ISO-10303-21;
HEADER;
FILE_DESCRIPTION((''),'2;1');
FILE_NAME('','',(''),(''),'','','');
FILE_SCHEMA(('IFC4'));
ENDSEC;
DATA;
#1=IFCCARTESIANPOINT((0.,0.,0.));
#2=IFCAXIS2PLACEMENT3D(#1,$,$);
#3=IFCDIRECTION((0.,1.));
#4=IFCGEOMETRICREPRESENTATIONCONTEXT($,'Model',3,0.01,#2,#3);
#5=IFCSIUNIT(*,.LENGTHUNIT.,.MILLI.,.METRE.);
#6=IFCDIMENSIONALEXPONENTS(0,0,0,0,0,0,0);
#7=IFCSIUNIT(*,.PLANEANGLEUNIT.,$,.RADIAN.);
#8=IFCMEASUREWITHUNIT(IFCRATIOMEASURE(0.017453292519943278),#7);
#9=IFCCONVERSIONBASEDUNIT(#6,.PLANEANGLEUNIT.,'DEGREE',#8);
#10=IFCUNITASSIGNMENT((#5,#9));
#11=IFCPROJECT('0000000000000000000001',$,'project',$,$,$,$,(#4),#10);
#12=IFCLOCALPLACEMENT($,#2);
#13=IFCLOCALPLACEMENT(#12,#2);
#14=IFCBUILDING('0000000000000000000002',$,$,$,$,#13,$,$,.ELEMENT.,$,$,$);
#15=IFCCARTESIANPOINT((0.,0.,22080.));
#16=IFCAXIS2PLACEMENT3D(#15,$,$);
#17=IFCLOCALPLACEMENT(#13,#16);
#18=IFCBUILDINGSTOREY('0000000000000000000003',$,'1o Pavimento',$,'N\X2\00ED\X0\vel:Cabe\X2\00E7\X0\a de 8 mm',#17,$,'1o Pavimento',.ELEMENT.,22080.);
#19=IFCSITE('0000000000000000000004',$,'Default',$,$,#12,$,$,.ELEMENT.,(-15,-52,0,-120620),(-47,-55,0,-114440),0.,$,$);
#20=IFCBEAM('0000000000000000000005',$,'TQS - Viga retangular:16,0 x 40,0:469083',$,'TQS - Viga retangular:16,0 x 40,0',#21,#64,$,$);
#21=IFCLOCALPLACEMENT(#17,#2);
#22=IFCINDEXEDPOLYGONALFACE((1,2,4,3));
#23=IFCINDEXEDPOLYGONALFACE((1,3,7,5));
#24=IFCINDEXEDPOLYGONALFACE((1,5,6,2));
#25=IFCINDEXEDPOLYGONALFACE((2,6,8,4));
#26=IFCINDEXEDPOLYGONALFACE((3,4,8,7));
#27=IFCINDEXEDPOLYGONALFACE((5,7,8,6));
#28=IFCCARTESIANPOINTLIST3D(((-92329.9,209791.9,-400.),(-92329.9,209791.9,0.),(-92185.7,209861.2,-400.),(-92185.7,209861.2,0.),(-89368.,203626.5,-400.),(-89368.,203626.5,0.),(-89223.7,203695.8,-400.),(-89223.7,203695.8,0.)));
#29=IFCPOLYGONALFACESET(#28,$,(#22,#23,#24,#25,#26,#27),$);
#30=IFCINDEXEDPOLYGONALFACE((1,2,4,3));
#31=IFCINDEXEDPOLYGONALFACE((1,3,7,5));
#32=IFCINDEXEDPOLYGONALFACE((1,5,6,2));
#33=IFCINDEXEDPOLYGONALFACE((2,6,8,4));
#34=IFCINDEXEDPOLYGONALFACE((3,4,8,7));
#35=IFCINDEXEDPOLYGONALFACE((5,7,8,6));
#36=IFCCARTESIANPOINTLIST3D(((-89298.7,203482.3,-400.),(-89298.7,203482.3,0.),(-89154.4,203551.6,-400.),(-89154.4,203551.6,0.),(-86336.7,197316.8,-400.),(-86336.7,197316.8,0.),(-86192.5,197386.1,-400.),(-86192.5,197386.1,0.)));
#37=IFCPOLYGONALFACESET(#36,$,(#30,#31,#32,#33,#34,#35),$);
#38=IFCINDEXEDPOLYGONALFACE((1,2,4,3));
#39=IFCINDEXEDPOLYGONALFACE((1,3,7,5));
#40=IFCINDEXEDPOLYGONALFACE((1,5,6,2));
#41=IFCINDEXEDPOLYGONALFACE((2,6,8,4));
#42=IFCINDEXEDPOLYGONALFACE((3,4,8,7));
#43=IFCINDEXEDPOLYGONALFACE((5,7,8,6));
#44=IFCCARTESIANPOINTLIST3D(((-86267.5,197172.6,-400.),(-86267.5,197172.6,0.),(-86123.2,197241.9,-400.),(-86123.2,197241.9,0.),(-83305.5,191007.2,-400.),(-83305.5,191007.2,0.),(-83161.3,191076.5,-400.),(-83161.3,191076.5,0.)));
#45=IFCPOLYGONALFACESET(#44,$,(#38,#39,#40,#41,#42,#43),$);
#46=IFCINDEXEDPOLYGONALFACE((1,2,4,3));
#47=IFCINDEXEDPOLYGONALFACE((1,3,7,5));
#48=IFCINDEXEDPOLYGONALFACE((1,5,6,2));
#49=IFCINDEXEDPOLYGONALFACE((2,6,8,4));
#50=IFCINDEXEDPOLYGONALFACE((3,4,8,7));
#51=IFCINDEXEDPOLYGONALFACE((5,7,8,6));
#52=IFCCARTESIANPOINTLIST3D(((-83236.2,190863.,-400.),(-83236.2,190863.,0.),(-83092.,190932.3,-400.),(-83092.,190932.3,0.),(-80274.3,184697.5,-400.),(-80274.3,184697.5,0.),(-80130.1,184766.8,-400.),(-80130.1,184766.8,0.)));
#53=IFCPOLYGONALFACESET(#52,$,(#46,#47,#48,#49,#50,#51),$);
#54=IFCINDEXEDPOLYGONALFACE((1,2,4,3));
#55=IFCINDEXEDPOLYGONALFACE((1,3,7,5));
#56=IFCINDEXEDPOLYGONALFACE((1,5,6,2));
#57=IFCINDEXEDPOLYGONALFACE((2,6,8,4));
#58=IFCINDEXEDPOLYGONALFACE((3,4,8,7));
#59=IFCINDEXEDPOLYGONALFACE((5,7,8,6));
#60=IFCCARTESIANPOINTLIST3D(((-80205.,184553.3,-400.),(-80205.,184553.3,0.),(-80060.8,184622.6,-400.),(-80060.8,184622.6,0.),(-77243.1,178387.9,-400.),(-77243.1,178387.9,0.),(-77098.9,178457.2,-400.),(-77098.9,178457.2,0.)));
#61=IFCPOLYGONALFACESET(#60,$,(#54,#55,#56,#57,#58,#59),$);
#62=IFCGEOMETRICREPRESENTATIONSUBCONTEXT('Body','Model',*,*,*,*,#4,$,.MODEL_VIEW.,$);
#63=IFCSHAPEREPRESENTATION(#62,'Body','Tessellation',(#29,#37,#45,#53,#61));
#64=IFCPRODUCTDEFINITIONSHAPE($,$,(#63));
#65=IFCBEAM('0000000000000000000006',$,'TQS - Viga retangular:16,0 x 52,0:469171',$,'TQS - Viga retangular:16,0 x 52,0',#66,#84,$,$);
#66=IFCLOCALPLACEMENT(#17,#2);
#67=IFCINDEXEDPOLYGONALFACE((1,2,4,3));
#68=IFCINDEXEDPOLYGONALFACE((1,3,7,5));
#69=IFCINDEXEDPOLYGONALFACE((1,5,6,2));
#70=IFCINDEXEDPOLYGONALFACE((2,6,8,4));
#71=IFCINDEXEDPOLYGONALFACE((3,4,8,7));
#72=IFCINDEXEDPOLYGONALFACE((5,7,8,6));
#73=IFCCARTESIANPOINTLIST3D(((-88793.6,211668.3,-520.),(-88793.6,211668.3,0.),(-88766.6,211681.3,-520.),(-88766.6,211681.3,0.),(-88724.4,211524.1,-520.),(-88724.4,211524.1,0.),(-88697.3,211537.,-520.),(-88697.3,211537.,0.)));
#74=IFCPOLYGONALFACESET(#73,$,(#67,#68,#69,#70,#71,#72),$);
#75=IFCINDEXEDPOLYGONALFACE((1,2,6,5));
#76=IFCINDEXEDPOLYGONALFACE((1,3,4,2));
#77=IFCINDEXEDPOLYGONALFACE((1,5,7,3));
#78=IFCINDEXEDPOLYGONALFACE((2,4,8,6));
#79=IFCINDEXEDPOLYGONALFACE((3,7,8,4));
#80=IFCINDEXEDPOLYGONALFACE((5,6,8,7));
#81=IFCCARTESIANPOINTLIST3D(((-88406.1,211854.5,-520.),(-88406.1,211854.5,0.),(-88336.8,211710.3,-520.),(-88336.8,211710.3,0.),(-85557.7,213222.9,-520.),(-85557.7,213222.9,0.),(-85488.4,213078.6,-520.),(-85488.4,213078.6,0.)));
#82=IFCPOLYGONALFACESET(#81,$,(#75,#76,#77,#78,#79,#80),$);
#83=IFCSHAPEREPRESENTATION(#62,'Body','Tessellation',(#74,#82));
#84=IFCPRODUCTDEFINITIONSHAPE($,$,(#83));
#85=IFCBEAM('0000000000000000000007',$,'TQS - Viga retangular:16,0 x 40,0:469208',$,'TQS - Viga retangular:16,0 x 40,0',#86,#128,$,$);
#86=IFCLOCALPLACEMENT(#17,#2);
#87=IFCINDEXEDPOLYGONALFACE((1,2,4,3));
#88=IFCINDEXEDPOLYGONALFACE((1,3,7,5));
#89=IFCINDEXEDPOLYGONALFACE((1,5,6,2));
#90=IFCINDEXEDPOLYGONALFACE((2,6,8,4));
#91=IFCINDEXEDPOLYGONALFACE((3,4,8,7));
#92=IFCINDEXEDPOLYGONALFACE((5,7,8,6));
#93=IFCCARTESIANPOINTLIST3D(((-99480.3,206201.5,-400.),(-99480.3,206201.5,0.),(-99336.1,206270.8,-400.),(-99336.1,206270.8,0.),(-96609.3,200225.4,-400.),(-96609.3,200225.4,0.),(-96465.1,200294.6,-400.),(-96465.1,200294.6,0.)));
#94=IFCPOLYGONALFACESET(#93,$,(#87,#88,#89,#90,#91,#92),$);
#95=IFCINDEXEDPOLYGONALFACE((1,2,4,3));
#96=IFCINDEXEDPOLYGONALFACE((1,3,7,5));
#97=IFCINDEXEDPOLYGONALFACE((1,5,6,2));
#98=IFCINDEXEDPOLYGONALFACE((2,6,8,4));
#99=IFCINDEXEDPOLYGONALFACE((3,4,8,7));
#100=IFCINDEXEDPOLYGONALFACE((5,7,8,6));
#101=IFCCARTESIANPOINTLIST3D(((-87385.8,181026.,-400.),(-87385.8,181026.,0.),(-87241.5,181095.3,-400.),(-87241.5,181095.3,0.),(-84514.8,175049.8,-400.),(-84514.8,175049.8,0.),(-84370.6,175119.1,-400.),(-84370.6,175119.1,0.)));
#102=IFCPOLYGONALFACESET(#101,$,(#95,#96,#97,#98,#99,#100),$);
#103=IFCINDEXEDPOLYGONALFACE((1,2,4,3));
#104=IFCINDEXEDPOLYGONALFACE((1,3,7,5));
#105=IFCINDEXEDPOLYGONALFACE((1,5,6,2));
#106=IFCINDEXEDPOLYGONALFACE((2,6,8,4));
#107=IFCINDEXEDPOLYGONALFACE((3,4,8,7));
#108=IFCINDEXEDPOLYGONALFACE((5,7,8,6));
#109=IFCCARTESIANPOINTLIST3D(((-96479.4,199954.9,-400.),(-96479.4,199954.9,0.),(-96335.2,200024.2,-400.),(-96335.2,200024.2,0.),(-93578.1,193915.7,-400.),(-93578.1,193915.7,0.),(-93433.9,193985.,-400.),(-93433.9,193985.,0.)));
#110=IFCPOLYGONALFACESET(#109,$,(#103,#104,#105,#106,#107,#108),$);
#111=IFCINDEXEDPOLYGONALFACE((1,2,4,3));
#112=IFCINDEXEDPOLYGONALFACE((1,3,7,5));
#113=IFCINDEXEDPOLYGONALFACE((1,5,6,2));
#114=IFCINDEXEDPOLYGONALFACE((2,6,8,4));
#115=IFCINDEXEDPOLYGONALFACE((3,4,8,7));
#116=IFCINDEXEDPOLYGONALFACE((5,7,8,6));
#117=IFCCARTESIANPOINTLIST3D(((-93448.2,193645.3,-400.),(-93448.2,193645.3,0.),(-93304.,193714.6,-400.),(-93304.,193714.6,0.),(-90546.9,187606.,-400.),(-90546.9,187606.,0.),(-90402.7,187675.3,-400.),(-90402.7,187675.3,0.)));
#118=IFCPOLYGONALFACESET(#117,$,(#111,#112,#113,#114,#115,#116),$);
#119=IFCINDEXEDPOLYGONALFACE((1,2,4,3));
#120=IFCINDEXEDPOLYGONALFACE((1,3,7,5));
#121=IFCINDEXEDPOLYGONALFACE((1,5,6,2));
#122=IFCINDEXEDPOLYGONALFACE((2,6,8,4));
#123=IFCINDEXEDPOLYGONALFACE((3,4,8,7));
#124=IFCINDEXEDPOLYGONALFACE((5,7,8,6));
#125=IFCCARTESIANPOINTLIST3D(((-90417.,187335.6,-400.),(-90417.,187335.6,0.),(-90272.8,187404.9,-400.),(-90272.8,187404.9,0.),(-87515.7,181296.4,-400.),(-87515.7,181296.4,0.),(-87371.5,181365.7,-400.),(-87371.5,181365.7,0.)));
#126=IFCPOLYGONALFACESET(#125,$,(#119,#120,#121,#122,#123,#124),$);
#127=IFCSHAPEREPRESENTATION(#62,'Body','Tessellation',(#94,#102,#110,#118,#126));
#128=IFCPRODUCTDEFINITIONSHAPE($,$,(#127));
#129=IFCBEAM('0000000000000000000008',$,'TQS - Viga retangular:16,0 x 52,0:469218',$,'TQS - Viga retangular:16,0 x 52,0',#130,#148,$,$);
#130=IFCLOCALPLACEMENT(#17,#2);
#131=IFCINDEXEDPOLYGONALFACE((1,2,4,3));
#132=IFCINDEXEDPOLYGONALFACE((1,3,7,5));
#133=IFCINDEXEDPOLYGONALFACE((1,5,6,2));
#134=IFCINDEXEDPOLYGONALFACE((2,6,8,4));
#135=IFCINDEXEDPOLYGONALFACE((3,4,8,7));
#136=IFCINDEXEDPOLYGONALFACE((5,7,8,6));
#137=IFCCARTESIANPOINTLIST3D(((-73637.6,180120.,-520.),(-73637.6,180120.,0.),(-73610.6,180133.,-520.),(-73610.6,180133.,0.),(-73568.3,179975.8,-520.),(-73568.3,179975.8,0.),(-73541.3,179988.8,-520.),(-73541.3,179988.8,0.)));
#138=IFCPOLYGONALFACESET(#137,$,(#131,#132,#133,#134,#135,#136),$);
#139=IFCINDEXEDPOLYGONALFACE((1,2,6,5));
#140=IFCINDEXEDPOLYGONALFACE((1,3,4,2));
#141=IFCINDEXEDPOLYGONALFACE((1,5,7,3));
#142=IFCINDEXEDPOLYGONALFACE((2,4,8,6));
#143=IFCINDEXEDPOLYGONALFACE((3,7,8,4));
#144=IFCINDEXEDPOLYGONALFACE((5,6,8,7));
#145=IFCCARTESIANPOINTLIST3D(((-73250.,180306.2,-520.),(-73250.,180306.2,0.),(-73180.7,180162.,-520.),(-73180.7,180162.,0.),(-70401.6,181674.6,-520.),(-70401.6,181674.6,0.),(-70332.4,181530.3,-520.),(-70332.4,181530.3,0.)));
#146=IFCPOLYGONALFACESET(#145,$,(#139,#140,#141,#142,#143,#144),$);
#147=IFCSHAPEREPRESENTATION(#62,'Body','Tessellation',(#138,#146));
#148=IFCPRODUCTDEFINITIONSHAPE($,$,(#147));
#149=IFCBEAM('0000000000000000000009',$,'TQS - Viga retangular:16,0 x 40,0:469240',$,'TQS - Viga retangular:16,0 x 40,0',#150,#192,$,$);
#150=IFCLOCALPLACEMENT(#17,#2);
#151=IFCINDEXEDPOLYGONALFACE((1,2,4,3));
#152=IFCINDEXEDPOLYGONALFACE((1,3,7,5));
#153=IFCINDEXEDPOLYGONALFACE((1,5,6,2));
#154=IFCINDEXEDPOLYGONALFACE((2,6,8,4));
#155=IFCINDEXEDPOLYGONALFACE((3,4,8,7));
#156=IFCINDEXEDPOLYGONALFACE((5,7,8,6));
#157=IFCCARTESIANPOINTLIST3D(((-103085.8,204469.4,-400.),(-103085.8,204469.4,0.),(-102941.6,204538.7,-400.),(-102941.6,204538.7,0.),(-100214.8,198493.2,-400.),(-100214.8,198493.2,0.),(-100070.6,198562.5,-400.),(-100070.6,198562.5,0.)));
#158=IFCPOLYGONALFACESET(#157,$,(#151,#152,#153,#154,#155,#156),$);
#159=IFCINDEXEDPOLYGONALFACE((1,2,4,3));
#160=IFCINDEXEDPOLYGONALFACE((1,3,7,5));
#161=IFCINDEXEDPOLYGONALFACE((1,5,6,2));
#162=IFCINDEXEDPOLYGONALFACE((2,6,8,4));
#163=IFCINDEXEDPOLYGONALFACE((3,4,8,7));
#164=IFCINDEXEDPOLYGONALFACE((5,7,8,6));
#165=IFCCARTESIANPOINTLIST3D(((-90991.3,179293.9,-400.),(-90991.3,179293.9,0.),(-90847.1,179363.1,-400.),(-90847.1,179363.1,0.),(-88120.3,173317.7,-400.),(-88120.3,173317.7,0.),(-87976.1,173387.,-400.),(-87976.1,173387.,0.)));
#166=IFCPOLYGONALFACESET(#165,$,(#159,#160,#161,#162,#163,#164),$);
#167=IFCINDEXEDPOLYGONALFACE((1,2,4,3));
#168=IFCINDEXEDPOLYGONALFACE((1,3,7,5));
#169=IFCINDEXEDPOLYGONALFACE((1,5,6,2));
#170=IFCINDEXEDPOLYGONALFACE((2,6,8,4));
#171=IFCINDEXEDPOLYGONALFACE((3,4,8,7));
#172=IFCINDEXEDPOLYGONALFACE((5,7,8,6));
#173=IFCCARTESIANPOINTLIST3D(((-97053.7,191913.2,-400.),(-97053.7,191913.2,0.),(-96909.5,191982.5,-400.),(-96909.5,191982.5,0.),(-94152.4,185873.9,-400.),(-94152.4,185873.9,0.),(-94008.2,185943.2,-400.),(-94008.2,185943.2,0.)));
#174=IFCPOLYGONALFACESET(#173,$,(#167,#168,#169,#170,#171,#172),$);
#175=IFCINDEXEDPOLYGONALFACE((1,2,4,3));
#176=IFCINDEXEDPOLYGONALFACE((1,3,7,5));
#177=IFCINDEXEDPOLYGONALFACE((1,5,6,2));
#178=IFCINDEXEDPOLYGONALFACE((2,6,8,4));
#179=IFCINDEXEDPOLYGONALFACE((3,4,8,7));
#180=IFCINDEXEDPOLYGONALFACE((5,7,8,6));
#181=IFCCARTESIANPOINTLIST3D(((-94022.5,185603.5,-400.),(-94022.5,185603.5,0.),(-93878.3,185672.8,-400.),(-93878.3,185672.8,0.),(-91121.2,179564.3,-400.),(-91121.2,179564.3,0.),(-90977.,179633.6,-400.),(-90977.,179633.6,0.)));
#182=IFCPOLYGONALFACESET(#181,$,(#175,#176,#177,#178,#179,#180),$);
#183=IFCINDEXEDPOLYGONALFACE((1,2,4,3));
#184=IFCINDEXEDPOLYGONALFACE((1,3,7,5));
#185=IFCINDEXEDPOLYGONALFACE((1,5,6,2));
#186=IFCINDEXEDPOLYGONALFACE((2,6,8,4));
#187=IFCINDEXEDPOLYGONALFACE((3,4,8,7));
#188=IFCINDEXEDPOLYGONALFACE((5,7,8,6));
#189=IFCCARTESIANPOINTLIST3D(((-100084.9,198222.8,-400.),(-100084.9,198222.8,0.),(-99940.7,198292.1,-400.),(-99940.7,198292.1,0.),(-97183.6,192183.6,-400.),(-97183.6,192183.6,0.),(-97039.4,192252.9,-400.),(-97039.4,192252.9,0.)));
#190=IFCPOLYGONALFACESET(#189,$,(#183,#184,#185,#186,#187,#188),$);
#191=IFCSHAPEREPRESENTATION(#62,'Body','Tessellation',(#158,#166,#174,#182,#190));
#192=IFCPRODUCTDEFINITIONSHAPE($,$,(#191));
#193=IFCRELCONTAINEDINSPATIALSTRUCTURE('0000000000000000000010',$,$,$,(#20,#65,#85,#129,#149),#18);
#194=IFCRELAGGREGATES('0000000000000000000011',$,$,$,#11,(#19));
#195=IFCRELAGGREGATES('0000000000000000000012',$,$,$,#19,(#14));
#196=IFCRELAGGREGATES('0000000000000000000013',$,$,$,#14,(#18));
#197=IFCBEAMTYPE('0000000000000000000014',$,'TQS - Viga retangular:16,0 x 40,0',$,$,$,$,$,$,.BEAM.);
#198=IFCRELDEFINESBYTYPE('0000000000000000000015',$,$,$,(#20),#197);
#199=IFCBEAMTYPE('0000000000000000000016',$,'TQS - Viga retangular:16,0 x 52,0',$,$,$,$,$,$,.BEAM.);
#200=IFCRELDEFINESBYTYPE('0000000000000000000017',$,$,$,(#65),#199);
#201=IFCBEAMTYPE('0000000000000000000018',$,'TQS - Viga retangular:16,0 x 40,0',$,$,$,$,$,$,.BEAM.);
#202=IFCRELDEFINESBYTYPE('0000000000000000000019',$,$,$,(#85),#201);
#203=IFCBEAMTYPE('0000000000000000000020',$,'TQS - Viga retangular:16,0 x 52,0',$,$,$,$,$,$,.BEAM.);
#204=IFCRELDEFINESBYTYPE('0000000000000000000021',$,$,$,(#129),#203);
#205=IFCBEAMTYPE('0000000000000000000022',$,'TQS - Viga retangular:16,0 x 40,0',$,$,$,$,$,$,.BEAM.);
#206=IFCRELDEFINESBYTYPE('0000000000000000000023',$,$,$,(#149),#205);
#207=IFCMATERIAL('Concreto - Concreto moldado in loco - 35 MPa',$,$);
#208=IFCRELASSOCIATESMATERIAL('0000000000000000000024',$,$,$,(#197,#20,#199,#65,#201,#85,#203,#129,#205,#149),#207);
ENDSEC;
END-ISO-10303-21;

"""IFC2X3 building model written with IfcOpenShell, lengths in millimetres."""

from ifc_helpers import new_model, entity, si_unit, converted_unit, direction, frame, frame_2d, origin, place, context, subcontext, project, spatial, rectangle, extrude, source, transform, mapped, material, type_object, type_shapes, element, save


model = new_model("IFC2X3")

# Units and contexts
model_context = context("Model", 3, precision=0.01, world=origin(), true_north=direction((0.0, 1.0)))
body_context = subcontext(model_context, "Body", "Model", "MODEL_VIEW")
ifc_project = project(units=[si_unit("LENGTHUNIT", "METRE", prefix="MILLI"), converted_unit("PLANEANGLEUNIT", "DEGREE", entity("IfcRatioMeasure", 0.017453292519943278), si_unit("PLANEANGLEUNIT", "RADIAN"), dimensions=[0, 0, 0, 0, 0, 0, 0])], contexts=[model_context])

# Site, building, storey
site_placement = place(None, origin())
site = spatial("IfcSite", under=ifc_project, at=site_placement, Name="Default", CompositionType="ELEMENT", RefLatitude=(-15, -52, 0, -120620), RefLongitude=(-47, -55, 0, -114440), RefElevation=0.0)
building_placement = place(site_placement, origin())
building = spatial("IfcBuilding", under=site, at=building_placement, CompositionType="ELEMENT")
storey_placement = place(building_placement, frame((0.0, 0.0, 22080.0)))
storey = spatial("IfcBuildingStorey", under=building, at=storey_placement, Name="1o Pavimento", ObjectType="Nível:Cabeça de 8 mm", LongName="1o Pavimento", CompositionType="ELEMENT", Elevation=22080.0)

# Beams
ifc_material_1 = material(Name="Concreto - Concreto moldado in loco - 35 MPa")
beam_type_1 = type_object("IfcBeamType", Name="TQS - Viga retangular:16,0 x 40,0", PredefinedType="BEAM", material=ifc_material_1)
shared_shape_1 = source(origin(), body_context, "Body", "SweptSolid", [
    extrude(rectangle(XDim=400.0, YDim=160.0, at=frame_2d((0.0, 0.0), x_axis=(1.0, 0.0))), frame((-89295.8, 203661.1, 21880.0), z_axis=(-0.43303, 0.90138, 0.0), x_axis=(0.0, 0.0, 1.0)), (0.0, 0.0, 1.0), 6840.0),
    extrude(rectangle(XDim=400.0, YDim=160.0, at=frame_2d((0.0, 0.0), x_axis=(1.0, 0.0))), frame((-86264.6, 197351.5, 21880.0), z_axis=(-0.43303, 0.90138, 0.0), x_axis=(0.0, 0.0, 1.0)), (0.0, 0.0, 1.0), 6840.0),
    extrude(rectangle(XDim=400.0, YDim=160.0, at=frame_2d((0.0, 0.0), x_axis=(1.0, 0.0))), frame((-83233.4, 191041.8, 21880.0), z_axis=(-0.43303, 0.90138, 0.0), x_axis=(0.0, 0.0, 1.0)), (0.0, 0.0, 1.0), 6840.0),
    extrude(rectangle(XDim=400.0, YDim=160.0, at=frame_2d((0.0, 0.0), x_axis=(1.0, 0.0))), frame((-80202.2, 184732.2, 21880.0), z_axis=(-0.43303, 0.90138, 0.0), x_axis=(0.0, 0.0, 1.0)), (0.0, 0.0, 1.0), 6840.0),
    extrude(rectangle(XDim=400.0, YDim=160.0, at=frame_2d((0.0, 0.0), x_axis=(1.0, 0.0))), frame((-77171.0, 178422.5, 21880.0), z_axis=(-0.43303, 0.90138, 0.0), x_axis=(0.0, 0.0, 1.0)), (0.0, 0.0, 1.0), 6840.0),
])
type_shapes(beam_type_1, [shared_shape_1])
beam_1_placement = place(storey_placement, frame((0.0, 0.0, -22080.0)))
element("IfcBeam", 1, at=beam_1_placement, inside=storey, type_object=beam_type_1, material=ifc_material_1, Name="TQS - Viga retangular:16,0 x 40,0:469083", ObjectType="TQS - Viga retangular:16,0 x 40,0", context=body_context, shape_type="MappedRepresentation", body=[
    mapped(shared_shape_1, transform((0.0, 0.0, 0.0), scale=1.0)),
])
beam_type_2 = type_object("IfcBeamType", Name="TQS - Viga retangular:16,0 x 52,0", PredefinedType="BEAM", material=ifc_material_1)
shared_shape_2 = source(origin(), body_context, "Body", "SweptSolid", [
    extrude(rectangle(XDim=520.0, YDim=160.0, at=frame_2d((0.0, 0.0), x_axis=(1.0, 0.0))), frame((-88732.0, 211609.2, 21820.0), z_axis=(-0.90138, -0.43303, 0.0), x_axis=(0.0, 0.0, -1.0)), (0.0, 0.0, 1.0), 30.0),
    extrude(rectangle(XDim=520.0, YDim=160.0, at=frame_2d((0.0, 0.0), x_axis=(1.0, 0.0))), frame((-85523.0, 213150.7, 21820.0), z_axis=(-0.90138, -0.43303, 0.0), x_axis=(0.0, 0.0, -1.0)), (0.0, 0.0, 1.0), 3160.0),
])
type_shapes(beam_type_2, [shared_shape_2])
beam_2_placement = place(storey_placement, frame((0.0, 0.0, -22080.0)))
element("IfcBeam", 2, at=beam_2_placement, inside=storey, type_object=beam_type_2, material=ifc_material_1, Name="TQS - Viga retangular:16,0 x 52,0:469171", ObjectType="TQS - Viga retangular:16,0 x 52,0", context=body_context, shape_type="MappedRepresentation", body=[
    mapped(shared_shape_2, transform((0.0, 0.0, 0.0), scale=1.0)),
])
beam_type_3 = type_object("IfcBeamType", Name="TQS - Viga retangular:16,0 x 40,0", PredefinedType="BEAM", material=ifc_material_1)
shared_shape_3 = source(origin(), body_context, "Body", "SweptSolid", [
    extrude(rectangle(XDim=400.0, YDim=160.0, at=frame_2d((0.0, 0.0), x_axis=(1.0, 0.0))), frame((-96537.2, 200260.0, 21880.0), z_axis=(-0.43303, 0.90138, 0.0), x_axis=(0.0, 0.0, 1.0)), (0.0, 0.0, 1.0), 6630.0),
    extrude(rectangle(XDim=400.0, YDim=160.0, at=frame_2d((0.0, 0.0), x_axis=(1.0, 0.0))), frame((-84442.7, 175084.5, 21880.0), z_axis=(-0.43303, 0.90138, 0.0), x_axis=(0.0, 0.0, 1.0)), (0.0, 0.0, 1.0), 6630.0),
    extrude(rectangle(XDim=400.0, YDim=160.0, at=frame_2d((0.0, 0.0), x_axis=(1.0, 0.0))), frame((-93506.0, 193950.3, 21880.0), z_axis=(-0.43303, 0.90138, 0.0), x_axis=(0.0, 0.0, 1.0)), (0.0, 0.0, 1.0), 6700.0),
    extrude(rectangle(XDim=400.0, YDim=160.0, at=frame_2d((0.0, 0.0), x_axis=(1.0, 0.0))), frame((-90474.8, 187640.7, 21880.0), z_axis=(-0.43303, 0.90138, 0.0), x_axis=(0.0, 0.0, 1.0)), (0.0, 0.0, 1.0), 6700.0),
    extrude(rectangle(XDim=400.0, YDim=160.0, at=frame_2d((0.0, 0.0), x_axis=(1.0, 0.0))), frame((-87443.6, 181331.0, 21880.0), z_axis=(-0.43303, 0.90138, 0.0), x_axis=(0.0, 0.0, 1.0)), (0.0, 0.0, 1.0), 6700.0),
])
type_shapes(beam_type_3, [shared_shape_3])
beam_3_placement = place(storey_placement, frame((0.0, 0.0, -22080.0)))
element("IfcBeam", 3, at=beam_3_placement, inside=storey, type_object=beam_type_3, material=ifc_material_1, Name="TQS - Viga retangular:16,0 x 40,0:469208", ObjectType="TQS - Viga retangular:16,0 x 40,0", context=body_context, shape_type="MappedRepresentation", body=[
    mapped(shared_shape_3, transform((0.0, 0.0, 0.0), scale=1.0)),
])
beam_type_4 = type_object("IfcBeamType", Name="TQS - Viga retangular:16,0 x 52,0", PredefinedType="BEAM", material=ifc_material_1)
shared_shape_4 = source(origin(), body_context, "Body", "SweptSolid", [
    extrude(rectangle(XDim=520.0, YDim=160.0, at=frame_2d((0.0, 0.0), x_axis=(1.0, 0.0))), frame((-73575.9, 180060.9, 21820.0), z_axis=(-0.90138, -0.43303, 0.0), x_axis=(0.0, 0.0, -1.0)), (0.0, 0.0, 1.0), 30.0),
    extrude(rectangle(XDim=520.0, YDim=160.0, at=frame_2d((0.0, 0.0), x_axis=(1.0, 0.0))), frame((-70367.0, 181602.5, 21820.0), z_axis=(-0.90138, -0.43303, 0.0), x_axis=(0.0, 0.0, -1.0)), (0.0, 0.0, 1.0), 3160.0),
])
type_shapes(beam_type_4, [shared_shape_4])
beam_4_placement = place(storey_placement, frame((0.0, 0.0, -22080.0)))
element("IfcBeam", 4, at=beam_4_placement, inside=storey, type_object=beam_type_4, material=ifc_material_1, Name="TQS - Viga retangular:16,0 x 52,0:469218", ObjectType="TQS - Viga retangular:16,0 x 52,0", context=body_context, shape_type="MappedRepresentation", body=[
    mapped(shared_shape_4, transform((0.0, 0.0, 0.0), scale=1.0)),
])
beam_type_5 = type_object("IfcBeamType", Name="TQS - Viga retangular:16,0 x 40,0", PredefinedType="BEAM", material=ifc_material_1)
shared_shape_5 = source(origin(), body_context, "Body", "SweptSolid", [
    extrude(rectangle(XDim=400.0, YDim=160.0, at=frame_2d((0.0, 0.0), x_axis=(1.0, 0.0))), frame((-100142.7, 198527.9, 21880.0), z_axis=(-0.43303, 0.90138, 0.0), x_axis=(0.0, 0.0, 1.0)), (0.0, 0.0, 1.0), 6630.0),
    extrude(rectangle(XDim=400.0, YDim=160.0, at=frame_2d((0.0, 0.0), x_axis=(1.0, 0.0))), frame((-88048.2, 173352.3, 21880.0), z_axis=(-0.43303, 0.90138, 0.0), x_axis=(0.0, 0.0, 1.0)), (0.0, 0.0, 1.0), 6630.0),
    extrude(rectangle(XDim=400.0, YDim=160.0, at=frame_2d((0.0, 0.0), x_axis=(1.0, 0.0))), frame((-94080.3, 185908.6, 21880.0), z_axis=(-0.43303, 0.90138, 0.0), x_axis=(0.0, 0.0, 1.0)), (0.0, 0.0, 1.0), 6700.0),
    extrude(rectangle(XDim=400.0, YDim=160.0, at=frame_2d((0.0, 0.0), x_axis=(1.0, 0.0))), frame((-91049.1, 179598.9, 21880.0), z_axis=(-0.43303, 0.90138, 0.0), x_axis=(0.0, 0.0, 1.0)), (0.0, 0.0, 1.0), 6700.0),
    extrude(rectangle(XDim=400.0, YDim=160.0, at=frame_2d((0.0, 0.0), x_axis=(1.0, 0.0))), frame((-97111.5, 192218.2, 21880.0), z_axis=(-0.43303, 0.90138, 0.0), x_axis=(0.0, 0.0, 1.0)), (0.0, 0.0, 1.0), 6700.0),
])
type_shapes(beam_type_5, [shared_shape_5])
beam_5_placement = place(storey_placement, frame((0.0, 0.0, -22080.0)))
element("IfcBeam", 5, at=beam_5_placement, inside=storey, type_object=beam_type_5, material=ifc_material_1, Name="TQS - Viga retangular:16,0 x 40,0:469240", ObjectType="TQS - Viga retangular:16,0 x 40,0", context=body_context, shape_type="MappedRepresentation", body=[
    mapped(shared_shape_5, transform((0.0, 0.0, 0.0), scale=1.0)),
])

save(model, "model.ifc")
